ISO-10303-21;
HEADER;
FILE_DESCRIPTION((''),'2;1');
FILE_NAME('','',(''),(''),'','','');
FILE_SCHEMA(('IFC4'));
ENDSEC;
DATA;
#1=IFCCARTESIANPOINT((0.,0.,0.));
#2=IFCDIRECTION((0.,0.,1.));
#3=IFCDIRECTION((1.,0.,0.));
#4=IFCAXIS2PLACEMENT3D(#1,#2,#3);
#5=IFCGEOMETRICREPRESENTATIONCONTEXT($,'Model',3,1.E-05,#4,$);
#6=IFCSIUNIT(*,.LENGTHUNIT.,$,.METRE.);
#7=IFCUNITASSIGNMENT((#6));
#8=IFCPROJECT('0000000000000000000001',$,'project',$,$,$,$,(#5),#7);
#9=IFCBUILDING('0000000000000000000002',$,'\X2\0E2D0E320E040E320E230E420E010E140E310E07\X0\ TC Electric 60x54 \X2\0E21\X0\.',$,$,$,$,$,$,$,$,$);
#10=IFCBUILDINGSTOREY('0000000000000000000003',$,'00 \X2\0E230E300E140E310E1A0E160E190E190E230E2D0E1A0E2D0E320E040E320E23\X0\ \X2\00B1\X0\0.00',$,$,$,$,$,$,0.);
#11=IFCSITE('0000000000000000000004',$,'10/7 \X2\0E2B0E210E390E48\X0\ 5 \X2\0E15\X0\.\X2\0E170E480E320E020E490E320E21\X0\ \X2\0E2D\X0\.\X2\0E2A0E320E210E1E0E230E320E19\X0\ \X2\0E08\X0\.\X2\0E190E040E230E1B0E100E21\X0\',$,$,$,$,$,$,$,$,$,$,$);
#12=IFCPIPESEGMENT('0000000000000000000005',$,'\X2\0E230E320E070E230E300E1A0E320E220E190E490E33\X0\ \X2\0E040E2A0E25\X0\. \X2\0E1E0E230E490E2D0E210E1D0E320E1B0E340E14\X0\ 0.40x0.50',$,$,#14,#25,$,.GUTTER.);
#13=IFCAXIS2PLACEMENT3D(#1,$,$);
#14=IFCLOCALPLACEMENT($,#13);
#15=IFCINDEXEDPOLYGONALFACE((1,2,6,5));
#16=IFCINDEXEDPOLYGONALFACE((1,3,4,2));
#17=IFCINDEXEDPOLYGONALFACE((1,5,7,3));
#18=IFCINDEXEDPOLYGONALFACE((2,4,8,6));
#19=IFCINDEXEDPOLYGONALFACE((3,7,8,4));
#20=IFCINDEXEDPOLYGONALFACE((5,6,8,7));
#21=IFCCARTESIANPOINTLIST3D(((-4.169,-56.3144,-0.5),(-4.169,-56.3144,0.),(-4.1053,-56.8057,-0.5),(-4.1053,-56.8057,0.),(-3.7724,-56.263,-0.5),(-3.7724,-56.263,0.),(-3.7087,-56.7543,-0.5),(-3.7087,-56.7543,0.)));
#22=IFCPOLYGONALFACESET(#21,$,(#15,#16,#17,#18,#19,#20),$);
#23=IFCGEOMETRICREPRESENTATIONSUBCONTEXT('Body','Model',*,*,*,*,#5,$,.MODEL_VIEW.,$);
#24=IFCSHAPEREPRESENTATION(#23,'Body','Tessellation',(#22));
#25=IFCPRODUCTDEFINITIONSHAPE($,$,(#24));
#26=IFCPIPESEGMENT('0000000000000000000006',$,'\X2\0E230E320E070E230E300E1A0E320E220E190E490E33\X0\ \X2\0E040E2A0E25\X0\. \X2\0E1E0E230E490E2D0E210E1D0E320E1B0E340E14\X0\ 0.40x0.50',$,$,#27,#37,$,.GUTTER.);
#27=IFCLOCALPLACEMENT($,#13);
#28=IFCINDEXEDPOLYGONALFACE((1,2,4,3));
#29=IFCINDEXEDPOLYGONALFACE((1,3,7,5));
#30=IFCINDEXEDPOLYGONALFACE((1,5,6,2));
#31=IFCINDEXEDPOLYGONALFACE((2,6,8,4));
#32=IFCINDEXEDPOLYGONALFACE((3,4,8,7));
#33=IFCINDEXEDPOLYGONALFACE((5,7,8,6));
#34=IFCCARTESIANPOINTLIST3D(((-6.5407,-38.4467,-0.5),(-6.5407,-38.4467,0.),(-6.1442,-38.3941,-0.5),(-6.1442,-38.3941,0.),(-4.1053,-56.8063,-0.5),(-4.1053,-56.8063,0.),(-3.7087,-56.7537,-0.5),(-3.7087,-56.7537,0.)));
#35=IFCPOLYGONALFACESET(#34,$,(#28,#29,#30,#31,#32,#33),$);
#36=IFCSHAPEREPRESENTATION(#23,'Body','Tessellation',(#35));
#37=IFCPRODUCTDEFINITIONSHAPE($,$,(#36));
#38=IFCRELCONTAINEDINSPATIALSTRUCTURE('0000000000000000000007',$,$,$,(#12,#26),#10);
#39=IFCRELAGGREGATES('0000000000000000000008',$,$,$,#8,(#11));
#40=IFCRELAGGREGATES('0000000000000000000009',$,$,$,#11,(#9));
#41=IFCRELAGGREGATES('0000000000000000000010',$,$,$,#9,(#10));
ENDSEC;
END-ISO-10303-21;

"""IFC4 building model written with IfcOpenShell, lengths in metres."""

from ifc_helpers import new_model, si_unit, frame, origin, origin_with_axes, origin_2d, place, context, subcontext, project, spatial, rectangle, extrude, element, save


model = new_model("IFC4")

# Units and contexts
model_context = context("Model", 3, precision=1e-05, world=origin_with_axes())
body_context = subcontext(model_context, "Body", "Model", "MODEL_VIEW")
ifc_project = project(units=[si_unit("LENGTHUNIT", "METRE")], contexts=[model_context])

# Site, building, storey
site = spatial("IfcSite", under=ifc_project, Name="10/7 หมู่ 5 ต.ท่าข้าม อ.สามพราน จ.นครปฐม")
building = spatial("IfcBuilding", under=site, Name="อาคารโกดัง TC Electric 60x54 ม.")
storey = spatial("IfcBuildingStorey", under=building, Name="00 ระดับถนนรอบอาคาร ±0.00", Elevation=0.0)

# Pipe segments
pipe_segment_1_placement = place(None, frame((-3.9707, -56.2887, -0.25), z_axis=(0.1286, -0.9917, 0.0), x_axis=(-0.9917, -0.1286, 0.0)))
element("IfcPipeSegment", 1, at=pipe_segment_1_placement, inside=storey, Name="รางระบายน้ำ คสล. พร้อมฝาปิด 0.40x0.50", PredefinedType="GUTTER", context=body_context, shape_type="SweptSolid", body=[
    extrude(rectangle(XDim=0.4, YDim=0.5, at=origin_2d()), origin(), (0.0, 0.0, 1.0), 0.4954),
])
pipe_segment_2_placement = place(None, frame((-3.907, -56.78, -0.25), z_axis=(-0.1315, 0.9913, 0.0), x_axis=(0.9913, 0.1315, 0.0)))
element("IfcPipeSegment", 2, at=pipe_segment_2_placement, inside=storey, Name="รางระบายน้ำ คสล. พร้อมฝาปิด 0.40x0.50", PredefinedType="GUTTER", context=body_context, shape_type="SweptSolid", body=[
    extrude(rectangle(XDim=0.4, YDim=0.5, at=origin_2d()), origin(), (0.0, 0.0, 1.0), 18.5204),
])

save(model, "model.ifc")
